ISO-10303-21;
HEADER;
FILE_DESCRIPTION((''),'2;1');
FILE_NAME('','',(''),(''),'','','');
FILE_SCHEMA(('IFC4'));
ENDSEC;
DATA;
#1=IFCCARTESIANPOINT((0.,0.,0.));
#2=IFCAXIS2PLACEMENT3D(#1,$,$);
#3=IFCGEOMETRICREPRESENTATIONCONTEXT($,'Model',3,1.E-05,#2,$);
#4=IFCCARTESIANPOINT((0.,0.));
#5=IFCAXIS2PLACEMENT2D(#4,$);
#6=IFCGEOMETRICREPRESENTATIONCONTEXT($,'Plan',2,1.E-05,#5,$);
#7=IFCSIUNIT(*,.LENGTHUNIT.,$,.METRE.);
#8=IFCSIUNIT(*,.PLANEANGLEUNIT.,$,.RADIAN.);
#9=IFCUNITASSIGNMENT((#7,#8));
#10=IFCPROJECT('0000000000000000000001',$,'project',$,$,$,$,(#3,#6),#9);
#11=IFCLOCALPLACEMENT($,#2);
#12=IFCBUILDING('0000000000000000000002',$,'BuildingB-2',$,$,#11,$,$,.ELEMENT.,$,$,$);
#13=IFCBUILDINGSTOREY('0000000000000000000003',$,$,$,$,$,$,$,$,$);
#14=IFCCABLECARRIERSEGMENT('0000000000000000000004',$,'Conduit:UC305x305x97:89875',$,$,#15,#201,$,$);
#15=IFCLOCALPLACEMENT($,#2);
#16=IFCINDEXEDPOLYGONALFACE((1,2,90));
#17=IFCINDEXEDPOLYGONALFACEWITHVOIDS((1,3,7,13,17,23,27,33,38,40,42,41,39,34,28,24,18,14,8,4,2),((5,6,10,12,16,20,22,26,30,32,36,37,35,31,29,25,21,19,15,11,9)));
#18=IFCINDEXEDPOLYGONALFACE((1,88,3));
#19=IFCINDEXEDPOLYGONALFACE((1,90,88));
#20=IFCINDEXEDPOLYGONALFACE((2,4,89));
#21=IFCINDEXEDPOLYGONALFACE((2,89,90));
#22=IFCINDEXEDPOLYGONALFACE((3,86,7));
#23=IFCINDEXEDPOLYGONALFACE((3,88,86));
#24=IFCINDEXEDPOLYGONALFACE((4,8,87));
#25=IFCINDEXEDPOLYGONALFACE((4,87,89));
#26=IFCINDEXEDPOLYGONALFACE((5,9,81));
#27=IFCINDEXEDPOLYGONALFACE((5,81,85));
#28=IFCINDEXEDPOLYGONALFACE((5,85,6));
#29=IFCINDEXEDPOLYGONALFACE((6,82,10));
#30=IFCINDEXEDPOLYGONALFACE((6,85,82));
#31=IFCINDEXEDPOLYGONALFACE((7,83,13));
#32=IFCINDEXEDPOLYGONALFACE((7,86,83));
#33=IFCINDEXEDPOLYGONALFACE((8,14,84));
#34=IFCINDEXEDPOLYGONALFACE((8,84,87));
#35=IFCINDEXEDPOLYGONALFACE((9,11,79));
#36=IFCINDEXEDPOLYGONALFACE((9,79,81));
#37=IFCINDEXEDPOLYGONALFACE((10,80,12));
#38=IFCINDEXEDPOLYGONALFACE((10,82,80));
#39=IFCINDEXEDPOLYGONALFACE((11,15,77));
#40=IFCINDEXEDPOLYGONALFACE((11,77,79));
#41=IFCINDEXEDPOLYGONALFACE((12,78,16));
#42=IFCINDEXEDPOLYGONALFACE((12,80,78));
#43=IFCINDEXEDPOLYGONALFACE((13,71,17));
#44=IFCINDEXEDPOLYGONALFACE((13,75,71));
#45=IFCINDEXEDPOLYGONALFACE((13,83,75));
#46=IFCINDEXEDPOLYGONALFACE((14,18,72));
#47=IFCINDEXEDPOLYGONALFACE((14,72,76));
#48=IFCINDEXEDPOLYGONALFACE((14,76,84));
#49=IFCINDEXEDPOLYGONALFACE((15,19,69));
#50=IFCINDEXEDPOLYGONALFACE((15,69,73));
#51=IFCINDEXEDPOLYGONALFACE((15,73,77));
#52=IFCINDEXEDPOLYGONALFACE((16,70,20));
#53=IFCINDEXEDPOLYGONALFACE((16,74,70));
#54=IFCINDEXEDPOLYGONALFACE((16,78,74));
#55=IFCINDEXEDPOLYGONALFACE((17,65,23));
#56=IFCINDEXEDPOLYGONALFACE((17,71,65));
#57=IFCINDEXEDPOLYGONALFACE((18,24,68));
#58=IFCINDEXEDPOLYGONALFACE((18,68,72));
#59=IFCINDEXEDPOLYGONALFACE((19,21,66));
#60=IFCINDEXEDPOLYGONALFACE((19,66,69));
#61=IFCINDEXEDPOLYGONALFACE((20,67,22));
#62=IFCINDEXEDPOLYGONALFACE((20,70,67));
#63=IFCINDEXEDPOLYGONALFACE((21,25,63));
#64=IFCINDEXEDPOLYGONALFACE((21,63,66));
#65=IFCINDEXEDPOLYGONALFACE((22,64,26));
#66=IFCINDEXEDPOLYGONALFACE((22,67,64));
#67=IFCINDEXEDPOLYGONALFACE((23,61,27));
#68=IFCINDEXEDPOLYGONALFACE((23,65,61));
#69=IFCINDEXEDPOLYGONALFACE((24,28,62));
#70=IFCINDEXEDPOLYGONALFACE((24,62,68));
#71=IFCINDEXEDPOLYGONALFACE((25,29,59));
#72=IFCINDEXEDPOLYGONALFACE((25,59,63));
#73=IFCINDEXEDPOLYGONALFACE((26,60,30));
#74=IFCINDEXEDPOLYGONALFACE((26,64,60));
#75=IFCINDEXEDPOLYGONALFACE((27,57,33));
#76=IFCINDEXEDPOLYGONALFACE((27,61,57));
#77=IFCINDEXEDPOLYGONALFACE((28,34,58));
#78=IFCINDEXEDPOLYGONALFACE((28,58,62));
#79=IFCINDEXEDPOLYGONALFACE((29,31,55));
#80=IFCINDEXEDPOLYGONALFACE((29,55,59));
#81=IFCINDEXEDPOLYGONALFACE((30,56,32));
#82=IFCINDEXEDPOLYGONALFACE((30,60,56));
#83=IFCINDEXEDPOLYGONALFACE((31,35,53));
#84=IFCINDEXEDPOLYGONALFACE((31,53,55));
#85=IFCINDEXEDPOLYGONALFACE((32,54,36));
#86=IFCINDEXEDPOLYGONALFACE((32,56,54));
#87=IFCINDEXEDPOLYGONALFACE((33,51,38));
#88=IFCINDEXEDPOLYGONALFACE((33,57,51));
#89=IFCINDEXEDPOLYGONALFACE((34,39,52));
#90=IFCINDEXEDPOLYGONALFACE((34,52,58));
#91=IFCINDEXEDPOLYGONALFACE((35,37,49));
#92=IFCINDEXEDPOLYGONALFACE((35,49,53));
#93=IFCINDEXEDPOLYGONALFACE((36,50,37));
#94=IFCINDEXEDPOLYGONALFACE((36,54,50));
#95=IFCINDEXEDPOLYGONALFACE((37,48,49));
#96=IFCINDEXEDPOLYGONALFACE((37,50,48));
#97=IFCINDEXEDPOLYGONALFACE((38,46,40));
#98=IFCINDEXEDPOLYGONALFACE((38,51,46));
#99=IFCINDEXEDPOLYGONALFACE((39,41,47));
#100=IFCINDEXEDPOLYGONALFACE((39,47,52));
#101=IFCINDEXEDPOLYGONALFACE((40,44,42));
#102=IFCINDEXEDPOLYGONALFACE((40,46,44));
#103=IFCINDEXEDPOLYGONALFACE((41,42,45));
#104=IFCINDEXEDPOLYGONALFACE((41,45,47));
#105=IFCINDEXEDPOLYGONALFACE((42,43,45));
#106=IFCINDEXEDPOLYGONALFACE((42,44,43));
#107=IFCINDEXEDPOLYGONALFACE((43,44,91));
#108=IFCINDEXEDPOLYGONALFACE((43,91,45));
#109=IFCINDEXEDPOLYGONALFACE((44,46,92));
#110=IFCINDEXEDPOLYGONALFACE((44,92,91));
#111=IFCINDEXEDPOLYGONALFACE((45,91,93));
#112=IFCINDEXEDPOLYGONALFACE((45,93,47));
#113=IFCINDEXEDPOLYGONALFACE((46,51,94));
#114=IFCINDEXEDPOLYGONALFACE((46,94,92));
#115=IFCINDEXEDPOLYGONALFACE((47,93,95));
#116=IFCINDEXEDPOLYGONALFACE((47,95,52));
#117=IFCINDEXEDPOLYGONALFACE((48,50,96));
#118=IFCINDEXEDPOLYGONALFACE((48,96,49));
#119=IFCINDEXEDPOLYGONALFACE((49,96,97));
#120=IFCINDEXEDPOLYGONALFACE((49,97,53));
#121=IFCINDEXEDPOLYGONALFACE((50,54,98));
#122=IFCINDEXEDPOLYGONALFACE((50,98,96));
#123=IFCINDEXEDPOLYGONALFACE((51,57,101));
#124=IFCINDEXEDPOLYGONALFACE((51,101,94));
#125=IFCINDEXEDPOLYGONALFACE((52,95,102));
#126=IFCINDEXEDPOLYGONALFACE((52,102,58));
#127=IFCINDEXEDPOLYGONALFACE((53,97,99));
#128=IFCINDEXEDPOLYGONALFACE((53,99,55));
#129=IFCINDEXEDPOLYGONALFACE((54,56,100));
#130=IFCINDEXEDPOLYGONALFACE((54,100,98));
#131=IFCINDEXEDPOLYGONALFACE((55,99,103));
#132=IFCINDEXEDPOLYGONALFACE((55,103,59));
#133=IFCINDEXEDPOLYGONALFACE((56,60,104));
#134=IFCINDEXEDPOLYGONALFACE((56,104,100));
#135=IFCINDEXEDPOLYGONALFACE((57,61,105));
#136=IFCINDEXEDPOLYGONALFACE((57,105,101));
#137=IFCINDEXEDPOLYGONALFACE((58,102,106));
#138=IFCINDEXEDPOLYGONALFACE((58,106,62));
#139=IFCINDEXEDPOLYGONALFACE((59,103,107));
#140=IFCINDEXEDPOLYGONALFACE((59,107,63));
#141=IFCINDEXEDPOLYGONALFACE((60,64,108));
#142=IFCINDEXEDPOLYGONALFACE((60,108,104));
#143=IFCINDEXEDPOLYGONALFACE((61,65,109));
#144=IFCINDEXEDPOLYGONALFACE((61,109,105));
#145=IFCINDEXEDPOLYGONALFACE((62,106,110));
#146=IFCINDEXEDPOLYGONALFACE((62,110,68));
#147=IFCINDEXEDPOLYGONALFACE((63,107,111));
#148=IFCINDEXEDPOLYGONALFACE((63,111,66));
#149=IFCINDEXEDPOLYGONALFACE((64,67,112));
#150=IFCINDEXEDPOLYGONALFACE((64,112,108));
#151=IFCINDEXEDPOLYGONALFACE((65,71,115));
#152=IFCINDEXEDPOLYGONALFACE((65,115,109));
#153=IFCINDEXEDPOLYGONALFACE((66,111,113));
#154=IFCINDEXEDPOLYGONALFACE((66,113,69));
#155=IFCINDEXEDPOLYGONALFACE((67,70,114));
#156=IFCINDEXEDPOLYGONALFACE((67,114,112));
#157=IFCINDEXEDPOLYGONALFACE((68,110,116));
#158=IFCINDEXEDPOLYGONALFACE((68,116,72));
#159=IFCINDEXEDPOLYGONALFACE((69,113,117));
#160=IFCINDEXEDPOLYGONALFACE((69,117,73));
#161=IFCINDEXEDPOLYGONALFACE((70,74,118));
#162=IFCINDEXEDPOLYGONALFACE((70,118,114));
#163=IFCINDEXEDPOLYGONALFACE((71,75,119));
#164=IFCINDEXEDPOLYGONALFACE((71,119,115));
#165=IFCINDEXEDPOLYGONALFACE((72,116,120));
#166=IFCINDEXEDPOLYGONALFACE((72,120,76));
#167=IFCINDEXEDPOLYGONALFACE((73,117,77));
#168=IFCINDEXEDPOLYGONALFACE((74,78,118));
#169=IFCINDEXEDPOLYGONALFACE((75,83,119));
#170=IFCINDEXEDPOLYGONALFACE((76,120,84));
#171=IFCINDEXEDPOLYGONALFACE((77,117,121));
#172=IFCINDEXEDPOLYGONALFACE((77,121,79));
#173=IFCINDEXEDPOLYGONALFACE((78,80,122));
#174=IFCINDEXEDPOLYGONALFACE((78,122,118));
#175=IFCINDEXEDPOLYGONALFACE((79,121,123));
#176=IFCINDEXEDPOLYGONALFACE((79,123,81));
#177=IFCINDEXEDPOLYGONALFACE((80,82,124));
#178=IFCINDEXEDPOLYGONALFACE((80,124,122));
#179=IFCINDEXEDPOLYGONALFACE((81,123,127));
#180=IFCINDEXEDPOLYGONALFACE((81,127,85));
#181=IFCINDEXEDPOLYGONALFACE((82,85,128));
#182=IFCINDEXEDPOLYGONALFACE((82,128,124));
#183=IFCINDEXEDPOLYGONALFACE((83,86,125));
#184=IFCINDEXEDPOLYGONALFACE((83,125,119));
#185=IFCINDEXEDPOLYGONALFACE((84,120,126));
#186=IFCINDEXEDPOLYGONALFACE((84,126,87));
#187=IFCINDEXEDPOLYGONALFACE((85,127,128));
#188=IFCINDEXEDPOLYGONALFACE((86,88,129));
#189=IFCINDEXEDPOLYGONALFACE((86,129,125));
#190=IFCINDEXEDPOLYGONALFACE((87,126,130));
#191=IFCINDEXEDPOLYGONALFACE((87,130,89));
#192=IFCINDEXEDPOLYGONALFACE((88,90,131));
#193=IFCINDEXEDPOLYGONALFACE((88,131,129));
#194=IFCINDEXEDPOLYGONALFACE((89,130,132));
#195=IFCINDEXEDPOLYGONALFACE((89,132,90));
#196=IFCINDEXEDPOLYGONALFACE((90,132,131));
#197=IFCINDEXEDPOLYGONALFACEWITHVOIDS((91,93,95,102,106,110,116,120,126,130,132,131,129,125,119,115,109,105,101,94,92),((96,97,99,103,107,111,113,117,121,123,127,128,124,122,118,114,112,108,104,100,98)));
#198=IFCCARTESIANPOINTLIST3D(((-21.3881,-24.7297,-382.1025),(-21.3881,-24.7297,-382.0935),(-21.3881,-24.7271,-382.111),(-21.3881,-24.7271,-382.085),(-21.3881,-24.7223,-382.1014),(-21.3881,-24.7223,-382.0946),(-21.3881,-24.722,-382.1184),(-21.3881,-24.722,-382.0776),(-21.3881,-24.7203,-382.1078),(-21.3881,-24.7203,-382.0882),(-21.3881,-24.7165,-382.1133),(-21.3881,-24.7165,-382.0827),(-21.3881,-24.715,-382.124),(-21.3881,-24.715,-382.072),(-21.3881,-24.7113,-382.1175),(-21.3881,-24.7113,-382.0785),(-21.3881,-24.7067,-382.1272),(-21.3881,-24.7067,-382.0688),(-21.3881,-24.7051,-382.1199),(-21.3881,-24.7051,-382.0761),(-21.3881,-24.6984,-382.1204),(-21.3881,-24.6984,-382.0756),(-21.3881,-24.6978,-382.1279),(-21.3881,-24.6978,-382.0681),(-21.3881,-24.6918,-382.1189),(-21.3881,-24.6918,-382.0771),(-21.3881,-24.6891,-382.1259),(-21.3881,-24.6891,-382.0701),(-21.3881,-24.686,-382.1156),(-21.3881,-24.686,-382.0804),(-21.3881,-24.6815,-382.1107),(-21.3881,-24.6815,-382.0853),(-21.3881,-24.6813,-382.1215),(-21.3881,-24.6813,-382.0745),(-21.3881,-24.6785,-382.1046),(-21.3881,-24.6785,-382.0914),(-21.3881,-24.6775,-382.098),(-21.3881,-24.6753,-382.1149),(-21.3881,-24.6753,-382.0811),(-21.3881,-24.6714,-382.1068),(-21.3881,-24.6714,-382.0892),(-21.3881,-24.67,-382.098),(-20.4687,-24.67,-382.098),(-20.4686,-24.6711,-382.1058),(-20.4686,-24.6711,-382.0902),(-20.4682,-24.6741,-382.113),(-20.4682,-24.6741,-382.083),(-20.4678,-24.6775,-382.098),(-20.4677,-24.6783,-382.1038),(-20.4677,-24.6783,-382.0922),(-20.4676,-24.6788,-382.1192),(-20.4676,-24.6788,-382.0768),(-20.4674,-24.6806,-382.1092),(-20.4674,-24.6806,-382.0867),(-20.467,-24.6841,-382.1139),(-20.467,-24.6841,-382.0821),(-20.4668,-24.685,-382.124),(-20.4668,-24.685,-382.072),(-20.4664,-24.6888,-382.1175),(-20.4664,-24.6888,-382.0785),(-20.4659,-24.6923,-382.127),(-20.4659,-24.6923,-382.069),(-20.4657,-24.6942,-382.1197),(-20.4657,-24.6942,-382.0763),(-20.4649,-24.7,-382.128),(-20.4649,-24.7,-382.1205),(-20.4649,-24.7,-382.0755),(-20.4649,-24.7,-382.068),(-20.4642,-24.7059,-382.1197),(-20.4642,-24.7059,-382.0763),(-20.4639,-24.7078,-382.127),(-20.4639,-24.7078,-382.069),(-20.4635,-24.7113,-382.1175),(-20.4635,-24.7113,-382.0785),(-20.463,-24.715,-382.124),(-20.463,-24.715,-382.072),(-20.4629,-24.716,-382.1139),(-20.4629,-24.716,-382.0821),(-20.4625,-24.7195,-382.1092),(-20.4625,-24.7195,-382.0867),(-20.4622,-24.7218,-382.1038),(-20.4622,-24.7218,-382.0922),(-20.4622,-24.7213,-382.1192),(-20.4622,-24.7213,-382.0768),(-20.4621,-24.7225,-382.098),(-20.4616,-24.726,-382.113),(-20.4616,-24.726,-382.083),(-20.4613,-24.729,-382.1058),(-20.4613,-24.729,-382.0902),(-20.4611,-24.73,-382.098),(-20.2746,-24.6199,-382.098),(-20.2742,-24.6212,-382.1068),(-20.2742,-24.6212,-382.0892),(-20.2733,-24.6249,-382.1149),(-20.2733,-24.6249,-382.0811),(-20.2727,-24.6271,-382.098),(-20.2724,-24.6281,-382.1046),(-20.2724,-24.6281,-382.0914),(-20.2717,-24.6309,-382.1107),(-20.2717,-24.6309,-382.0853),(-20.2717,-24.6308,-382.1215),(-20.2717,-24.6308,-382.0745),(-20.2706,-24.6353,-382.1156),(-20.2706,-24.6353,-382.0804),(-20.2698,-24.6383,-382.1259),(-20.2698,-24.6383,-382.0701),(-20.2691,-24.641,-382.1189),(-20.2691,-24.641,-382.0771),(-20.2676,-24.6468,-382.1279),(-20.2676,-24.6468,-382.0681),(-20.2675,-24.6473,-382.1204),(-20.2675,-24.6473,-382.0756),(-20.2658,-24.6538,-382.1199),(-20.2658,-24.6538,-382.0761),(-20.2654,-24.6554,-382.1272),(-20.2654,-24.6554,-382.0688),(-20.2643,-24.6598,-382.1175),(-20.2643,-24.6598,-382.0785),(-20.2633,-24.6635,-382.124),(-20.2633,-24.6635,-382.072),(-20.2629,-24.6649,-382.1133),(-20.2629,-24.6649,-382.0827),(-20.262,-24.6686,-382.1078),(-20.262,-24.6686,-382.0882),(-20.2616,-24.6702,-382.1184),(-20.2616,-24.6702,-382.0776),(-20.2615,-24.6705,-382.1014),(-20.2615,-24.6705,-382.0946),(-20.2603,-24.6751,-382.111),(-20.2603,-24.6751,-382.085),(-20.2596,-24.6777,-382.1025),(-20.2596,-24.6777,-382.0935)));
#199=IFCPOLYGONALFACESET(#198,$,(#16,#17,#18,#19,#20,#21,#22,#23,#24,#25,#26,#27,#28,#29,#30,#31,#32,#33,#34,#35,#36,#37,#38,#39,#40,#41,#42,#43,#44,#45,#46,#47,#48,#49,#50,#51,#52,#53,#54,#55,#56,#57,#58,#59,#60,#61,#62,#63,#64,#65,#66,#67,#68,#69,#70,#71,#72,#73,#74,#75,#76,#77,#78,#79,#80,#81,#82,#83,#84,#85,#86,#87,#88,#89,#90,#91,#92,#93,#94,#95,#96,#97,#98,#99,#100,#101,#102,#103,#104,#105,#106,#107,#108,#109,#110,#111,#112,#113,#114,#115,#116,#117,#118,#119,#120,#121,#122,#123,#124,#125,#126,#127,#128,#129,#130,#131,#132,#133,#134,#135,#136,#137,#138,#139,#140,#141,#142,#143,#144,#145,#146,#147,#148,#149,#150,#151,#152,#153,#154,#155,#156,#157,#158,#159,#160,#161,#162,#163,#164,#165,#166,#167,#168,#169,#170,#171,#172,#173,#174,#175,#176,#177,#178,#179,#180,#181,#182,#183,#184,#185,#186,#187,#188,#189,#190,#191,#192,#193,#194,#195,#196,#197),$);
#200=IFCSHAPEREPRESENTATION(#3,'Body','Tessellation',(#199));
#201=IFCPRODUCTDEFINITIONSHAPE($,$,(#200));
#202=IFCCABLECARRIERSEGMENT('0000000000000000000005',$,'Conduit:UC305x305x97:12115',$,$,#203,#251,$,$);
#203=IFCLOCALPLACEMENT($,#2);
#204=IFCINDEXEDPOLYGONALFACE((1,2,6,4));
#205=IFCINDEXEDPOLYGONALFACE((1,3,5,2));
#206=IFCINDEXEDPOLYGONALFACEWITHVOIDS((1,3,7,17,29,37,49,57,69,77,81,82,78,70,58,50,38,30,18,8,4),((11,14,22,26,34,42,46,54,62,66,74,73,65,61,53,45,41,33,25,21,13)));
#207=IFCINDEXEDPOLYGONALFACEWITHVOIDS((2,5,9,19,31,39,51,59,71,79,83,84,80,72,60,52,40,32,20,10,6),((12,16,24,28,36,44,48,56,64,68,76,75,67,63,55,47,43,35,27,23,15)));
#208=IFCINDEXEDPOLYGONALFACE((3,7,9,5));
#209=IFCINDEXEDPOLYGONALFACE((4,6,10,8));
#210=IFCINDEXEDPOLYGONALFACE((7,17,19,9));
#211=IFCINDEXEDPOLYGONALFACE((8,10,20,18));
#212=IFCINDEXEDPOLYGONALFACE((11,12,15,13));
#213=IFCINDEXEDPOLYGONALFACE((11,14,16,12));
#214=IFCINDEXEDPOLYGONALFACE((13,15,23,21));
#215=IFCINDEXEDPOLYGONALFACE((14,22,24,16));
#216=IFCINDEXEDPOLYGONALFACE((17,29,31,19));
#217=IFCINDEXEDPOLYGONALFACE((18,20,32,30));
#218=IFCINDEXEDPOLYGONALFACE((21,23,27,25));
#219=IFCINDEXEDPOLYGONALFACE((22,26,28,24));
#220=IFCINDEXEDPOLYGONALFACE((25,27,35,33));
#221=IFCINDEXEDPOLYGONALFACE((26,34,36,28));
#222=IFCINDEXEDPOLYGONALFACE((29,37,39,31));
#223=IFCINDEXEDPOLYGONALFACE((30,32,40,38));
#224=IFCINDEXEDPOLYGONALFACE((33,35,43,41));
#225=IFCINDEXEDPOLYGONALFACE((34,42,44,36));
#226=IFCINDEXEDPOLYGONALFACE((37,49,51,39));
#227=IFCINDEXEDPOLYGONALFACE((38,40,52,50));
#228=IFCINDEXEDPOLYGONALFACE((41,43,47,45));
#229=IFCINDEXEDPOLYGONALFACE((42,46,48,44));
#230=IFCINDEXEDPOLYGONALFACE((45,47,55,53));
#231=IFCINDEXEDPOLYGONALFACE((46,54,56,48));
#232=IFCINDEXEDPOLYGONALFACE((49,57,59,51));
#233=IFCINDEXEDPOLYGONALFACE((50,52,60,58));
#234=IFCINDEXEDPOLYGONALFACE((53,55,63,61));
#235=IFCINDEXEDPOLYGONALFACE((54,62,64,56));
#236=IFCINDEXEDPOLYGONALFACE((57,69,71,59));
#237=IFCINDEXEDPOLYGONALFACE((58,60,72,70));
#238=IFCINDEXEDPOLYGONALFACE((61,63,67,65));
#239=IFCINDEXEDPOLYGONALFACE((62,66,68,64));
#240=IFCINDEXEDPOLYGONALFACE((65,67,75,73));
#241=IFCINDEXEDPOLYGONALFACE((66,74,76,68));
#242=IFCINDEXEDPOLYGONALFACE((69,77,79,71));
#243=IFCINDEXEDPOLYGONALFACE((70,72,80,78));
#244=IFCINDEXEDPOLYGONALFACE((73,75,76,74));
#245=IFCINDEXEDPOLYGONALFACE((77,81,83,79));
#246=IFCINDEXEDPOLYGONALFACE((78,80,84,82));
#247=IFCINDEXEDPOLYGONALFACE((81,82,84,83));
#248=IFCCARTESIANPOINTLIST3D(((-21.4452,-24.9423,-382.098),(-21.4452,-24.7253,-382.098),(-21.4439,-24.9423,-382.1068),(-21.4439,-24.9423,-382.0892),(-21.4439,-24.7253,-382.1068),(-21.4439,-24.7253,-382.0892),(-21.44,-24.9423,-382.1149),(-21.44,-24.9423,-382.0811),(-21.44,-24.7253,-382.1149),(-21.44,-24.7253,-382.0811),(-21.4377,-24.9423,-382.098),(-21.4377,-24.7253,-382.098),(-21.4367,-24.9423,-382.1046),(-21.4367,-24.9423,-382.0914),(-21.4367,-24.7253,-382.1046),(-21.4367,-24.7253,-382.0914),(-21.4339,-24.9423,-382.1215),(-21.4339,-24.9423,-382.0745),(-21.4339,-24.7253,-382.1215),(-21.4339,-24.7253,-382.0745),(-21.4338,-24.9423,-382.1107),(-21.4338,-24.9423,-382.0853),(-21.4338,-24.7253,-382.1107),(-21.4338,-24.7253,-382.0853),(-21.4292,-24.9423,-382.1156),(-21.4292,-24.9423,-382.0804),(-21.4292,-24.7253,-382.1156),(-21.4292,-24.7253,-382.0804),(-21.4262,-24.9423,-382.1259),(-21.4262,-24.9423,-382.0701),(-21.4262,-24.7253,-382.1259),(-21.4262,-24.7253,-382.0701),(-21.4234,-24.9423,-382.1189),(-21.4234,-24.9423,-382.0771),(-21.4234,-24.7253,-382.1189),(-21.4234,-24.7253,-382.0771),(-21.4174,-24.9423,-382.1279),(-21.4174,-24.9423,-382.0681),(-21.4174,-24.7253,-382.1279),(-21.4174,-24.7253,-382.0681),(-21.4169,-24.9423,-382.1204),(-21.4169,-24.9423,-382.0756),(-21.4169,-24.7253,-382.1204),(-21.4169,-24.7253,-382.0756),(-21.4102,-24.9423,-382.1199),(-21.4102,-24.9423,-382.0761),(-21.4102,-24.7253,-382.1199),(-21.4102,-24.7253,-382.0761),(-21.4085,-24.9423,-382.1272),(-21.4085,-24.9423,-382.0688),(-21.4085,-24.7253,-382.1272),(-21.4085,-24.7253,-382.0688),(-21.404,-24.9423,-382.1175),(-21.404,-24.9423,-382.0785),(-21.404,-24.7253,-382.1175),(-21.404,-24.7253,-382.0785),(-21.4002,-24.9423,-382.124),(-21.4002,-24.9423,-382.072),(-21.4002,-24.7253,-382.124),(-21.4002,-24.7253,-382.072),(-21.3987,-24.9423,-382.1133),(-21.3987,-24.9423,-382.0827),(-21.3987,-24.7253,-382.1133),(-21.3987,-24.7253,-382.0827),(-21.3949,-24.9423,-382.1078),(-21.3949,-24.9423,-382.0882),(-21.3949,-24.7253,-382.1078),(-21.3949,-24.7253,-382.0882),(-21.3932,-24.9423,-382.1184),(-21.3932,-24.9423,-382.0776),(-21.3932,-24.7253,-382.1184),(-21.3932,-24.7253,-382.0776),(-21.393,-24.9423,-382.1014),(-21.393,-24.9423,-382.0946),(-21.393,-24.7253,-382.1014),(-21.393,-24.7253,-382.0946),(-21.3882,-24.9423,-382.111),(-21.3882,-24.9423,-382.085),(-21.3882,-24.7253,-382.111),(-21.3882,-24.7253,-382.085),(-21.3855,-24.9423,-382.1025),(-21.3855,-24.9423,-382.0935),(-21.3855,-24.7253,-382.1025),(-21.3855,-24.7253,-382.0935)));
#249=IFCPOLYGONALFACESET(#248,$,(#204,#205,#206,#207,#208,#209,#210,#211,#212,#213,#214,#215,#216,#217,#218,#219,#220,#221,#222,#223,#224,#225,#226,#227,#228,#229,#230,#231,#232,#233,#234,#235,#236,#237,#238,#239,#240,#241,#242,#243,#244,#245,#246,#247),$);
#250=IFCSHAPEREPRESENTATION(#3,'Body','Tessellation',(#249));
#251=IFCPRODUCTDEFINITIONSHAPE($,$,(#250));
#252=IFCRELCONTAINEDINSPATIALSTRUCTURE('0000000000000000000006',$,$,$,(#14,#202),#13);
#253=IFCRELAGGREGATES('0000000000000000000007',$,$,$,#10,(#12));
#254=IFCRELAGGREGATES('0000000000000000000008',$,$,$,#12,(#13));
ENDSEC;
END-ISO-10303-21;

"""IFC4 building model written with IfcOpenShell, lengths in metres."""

from ifc_helpers import new_model, entity, si_unit, origin, origin_2d, place, context, project, spatial, element, save


model = new_model("IFC4")

# Units and contexts
model_context = context("Model", 3, precision=1e-05, world=origin())
plan_context = context("Plan", 2, precision=1e-05, world=origin_2d())
ifc_project = project(units=[si_unit("LENGTHUNIT", "METRE"), si_unit("PLANEANGLEUNIT", "RADIAN")], contexts=[model_context, plan_context])

# Building, storey
building_placement = place(None, origin())
building = spatial("IfcBuilding", under=ifc_project, at=building_placement, Name="BuildingB-2", CompositionType="ELEMENT")
storey = spatial("IfcBuildingStorey", under=building)

# Cable carrier segments
element("IfcCableCarrierSegment", 1, inside=storey, Name="Conduit:UC305x305x97:89875", context=model_context, shape_type="AdvancedSweptSolid", body=[
    entity("IfcSweptDiskSolid", entity("IfcCompositeCurve", [entity("IfcCompositeCurveSegment", "CONTINUOUS", False, entity("IfcPolyline", [entity("IfcCartesianPoint", [19.9044, 24.6745, 382.098]), entity("IfcCartesianPoint", [20.8276, 24.6745, 382.098]), entity("IfcCartesianPoint", [21.0254, 24.7256, 382.098])]))], False), 0.03, 0.0225),
])
element("IfcCableCarrierSegment", 2, inside=storey, Name="Conduit:UC305x305x97:12115", context=model_context, shape_type="AdvancedSweptSolid", body=[
    entity("IfcSweptDiskSolid", entity("IfcCompositeCurve", [entity("IfcCompositeCurveSegment", "CONTINUOUS", False, entity("IfcPolyline", [entity("IfcCartesianPoint", [21.4152, 24.9423, 382.098]), entity("IfcCartesianPoint", [21.4152, 24.7253, 382.098])]))], False), 0.03, 0.0225),
])

save(model, "model.ifc")
